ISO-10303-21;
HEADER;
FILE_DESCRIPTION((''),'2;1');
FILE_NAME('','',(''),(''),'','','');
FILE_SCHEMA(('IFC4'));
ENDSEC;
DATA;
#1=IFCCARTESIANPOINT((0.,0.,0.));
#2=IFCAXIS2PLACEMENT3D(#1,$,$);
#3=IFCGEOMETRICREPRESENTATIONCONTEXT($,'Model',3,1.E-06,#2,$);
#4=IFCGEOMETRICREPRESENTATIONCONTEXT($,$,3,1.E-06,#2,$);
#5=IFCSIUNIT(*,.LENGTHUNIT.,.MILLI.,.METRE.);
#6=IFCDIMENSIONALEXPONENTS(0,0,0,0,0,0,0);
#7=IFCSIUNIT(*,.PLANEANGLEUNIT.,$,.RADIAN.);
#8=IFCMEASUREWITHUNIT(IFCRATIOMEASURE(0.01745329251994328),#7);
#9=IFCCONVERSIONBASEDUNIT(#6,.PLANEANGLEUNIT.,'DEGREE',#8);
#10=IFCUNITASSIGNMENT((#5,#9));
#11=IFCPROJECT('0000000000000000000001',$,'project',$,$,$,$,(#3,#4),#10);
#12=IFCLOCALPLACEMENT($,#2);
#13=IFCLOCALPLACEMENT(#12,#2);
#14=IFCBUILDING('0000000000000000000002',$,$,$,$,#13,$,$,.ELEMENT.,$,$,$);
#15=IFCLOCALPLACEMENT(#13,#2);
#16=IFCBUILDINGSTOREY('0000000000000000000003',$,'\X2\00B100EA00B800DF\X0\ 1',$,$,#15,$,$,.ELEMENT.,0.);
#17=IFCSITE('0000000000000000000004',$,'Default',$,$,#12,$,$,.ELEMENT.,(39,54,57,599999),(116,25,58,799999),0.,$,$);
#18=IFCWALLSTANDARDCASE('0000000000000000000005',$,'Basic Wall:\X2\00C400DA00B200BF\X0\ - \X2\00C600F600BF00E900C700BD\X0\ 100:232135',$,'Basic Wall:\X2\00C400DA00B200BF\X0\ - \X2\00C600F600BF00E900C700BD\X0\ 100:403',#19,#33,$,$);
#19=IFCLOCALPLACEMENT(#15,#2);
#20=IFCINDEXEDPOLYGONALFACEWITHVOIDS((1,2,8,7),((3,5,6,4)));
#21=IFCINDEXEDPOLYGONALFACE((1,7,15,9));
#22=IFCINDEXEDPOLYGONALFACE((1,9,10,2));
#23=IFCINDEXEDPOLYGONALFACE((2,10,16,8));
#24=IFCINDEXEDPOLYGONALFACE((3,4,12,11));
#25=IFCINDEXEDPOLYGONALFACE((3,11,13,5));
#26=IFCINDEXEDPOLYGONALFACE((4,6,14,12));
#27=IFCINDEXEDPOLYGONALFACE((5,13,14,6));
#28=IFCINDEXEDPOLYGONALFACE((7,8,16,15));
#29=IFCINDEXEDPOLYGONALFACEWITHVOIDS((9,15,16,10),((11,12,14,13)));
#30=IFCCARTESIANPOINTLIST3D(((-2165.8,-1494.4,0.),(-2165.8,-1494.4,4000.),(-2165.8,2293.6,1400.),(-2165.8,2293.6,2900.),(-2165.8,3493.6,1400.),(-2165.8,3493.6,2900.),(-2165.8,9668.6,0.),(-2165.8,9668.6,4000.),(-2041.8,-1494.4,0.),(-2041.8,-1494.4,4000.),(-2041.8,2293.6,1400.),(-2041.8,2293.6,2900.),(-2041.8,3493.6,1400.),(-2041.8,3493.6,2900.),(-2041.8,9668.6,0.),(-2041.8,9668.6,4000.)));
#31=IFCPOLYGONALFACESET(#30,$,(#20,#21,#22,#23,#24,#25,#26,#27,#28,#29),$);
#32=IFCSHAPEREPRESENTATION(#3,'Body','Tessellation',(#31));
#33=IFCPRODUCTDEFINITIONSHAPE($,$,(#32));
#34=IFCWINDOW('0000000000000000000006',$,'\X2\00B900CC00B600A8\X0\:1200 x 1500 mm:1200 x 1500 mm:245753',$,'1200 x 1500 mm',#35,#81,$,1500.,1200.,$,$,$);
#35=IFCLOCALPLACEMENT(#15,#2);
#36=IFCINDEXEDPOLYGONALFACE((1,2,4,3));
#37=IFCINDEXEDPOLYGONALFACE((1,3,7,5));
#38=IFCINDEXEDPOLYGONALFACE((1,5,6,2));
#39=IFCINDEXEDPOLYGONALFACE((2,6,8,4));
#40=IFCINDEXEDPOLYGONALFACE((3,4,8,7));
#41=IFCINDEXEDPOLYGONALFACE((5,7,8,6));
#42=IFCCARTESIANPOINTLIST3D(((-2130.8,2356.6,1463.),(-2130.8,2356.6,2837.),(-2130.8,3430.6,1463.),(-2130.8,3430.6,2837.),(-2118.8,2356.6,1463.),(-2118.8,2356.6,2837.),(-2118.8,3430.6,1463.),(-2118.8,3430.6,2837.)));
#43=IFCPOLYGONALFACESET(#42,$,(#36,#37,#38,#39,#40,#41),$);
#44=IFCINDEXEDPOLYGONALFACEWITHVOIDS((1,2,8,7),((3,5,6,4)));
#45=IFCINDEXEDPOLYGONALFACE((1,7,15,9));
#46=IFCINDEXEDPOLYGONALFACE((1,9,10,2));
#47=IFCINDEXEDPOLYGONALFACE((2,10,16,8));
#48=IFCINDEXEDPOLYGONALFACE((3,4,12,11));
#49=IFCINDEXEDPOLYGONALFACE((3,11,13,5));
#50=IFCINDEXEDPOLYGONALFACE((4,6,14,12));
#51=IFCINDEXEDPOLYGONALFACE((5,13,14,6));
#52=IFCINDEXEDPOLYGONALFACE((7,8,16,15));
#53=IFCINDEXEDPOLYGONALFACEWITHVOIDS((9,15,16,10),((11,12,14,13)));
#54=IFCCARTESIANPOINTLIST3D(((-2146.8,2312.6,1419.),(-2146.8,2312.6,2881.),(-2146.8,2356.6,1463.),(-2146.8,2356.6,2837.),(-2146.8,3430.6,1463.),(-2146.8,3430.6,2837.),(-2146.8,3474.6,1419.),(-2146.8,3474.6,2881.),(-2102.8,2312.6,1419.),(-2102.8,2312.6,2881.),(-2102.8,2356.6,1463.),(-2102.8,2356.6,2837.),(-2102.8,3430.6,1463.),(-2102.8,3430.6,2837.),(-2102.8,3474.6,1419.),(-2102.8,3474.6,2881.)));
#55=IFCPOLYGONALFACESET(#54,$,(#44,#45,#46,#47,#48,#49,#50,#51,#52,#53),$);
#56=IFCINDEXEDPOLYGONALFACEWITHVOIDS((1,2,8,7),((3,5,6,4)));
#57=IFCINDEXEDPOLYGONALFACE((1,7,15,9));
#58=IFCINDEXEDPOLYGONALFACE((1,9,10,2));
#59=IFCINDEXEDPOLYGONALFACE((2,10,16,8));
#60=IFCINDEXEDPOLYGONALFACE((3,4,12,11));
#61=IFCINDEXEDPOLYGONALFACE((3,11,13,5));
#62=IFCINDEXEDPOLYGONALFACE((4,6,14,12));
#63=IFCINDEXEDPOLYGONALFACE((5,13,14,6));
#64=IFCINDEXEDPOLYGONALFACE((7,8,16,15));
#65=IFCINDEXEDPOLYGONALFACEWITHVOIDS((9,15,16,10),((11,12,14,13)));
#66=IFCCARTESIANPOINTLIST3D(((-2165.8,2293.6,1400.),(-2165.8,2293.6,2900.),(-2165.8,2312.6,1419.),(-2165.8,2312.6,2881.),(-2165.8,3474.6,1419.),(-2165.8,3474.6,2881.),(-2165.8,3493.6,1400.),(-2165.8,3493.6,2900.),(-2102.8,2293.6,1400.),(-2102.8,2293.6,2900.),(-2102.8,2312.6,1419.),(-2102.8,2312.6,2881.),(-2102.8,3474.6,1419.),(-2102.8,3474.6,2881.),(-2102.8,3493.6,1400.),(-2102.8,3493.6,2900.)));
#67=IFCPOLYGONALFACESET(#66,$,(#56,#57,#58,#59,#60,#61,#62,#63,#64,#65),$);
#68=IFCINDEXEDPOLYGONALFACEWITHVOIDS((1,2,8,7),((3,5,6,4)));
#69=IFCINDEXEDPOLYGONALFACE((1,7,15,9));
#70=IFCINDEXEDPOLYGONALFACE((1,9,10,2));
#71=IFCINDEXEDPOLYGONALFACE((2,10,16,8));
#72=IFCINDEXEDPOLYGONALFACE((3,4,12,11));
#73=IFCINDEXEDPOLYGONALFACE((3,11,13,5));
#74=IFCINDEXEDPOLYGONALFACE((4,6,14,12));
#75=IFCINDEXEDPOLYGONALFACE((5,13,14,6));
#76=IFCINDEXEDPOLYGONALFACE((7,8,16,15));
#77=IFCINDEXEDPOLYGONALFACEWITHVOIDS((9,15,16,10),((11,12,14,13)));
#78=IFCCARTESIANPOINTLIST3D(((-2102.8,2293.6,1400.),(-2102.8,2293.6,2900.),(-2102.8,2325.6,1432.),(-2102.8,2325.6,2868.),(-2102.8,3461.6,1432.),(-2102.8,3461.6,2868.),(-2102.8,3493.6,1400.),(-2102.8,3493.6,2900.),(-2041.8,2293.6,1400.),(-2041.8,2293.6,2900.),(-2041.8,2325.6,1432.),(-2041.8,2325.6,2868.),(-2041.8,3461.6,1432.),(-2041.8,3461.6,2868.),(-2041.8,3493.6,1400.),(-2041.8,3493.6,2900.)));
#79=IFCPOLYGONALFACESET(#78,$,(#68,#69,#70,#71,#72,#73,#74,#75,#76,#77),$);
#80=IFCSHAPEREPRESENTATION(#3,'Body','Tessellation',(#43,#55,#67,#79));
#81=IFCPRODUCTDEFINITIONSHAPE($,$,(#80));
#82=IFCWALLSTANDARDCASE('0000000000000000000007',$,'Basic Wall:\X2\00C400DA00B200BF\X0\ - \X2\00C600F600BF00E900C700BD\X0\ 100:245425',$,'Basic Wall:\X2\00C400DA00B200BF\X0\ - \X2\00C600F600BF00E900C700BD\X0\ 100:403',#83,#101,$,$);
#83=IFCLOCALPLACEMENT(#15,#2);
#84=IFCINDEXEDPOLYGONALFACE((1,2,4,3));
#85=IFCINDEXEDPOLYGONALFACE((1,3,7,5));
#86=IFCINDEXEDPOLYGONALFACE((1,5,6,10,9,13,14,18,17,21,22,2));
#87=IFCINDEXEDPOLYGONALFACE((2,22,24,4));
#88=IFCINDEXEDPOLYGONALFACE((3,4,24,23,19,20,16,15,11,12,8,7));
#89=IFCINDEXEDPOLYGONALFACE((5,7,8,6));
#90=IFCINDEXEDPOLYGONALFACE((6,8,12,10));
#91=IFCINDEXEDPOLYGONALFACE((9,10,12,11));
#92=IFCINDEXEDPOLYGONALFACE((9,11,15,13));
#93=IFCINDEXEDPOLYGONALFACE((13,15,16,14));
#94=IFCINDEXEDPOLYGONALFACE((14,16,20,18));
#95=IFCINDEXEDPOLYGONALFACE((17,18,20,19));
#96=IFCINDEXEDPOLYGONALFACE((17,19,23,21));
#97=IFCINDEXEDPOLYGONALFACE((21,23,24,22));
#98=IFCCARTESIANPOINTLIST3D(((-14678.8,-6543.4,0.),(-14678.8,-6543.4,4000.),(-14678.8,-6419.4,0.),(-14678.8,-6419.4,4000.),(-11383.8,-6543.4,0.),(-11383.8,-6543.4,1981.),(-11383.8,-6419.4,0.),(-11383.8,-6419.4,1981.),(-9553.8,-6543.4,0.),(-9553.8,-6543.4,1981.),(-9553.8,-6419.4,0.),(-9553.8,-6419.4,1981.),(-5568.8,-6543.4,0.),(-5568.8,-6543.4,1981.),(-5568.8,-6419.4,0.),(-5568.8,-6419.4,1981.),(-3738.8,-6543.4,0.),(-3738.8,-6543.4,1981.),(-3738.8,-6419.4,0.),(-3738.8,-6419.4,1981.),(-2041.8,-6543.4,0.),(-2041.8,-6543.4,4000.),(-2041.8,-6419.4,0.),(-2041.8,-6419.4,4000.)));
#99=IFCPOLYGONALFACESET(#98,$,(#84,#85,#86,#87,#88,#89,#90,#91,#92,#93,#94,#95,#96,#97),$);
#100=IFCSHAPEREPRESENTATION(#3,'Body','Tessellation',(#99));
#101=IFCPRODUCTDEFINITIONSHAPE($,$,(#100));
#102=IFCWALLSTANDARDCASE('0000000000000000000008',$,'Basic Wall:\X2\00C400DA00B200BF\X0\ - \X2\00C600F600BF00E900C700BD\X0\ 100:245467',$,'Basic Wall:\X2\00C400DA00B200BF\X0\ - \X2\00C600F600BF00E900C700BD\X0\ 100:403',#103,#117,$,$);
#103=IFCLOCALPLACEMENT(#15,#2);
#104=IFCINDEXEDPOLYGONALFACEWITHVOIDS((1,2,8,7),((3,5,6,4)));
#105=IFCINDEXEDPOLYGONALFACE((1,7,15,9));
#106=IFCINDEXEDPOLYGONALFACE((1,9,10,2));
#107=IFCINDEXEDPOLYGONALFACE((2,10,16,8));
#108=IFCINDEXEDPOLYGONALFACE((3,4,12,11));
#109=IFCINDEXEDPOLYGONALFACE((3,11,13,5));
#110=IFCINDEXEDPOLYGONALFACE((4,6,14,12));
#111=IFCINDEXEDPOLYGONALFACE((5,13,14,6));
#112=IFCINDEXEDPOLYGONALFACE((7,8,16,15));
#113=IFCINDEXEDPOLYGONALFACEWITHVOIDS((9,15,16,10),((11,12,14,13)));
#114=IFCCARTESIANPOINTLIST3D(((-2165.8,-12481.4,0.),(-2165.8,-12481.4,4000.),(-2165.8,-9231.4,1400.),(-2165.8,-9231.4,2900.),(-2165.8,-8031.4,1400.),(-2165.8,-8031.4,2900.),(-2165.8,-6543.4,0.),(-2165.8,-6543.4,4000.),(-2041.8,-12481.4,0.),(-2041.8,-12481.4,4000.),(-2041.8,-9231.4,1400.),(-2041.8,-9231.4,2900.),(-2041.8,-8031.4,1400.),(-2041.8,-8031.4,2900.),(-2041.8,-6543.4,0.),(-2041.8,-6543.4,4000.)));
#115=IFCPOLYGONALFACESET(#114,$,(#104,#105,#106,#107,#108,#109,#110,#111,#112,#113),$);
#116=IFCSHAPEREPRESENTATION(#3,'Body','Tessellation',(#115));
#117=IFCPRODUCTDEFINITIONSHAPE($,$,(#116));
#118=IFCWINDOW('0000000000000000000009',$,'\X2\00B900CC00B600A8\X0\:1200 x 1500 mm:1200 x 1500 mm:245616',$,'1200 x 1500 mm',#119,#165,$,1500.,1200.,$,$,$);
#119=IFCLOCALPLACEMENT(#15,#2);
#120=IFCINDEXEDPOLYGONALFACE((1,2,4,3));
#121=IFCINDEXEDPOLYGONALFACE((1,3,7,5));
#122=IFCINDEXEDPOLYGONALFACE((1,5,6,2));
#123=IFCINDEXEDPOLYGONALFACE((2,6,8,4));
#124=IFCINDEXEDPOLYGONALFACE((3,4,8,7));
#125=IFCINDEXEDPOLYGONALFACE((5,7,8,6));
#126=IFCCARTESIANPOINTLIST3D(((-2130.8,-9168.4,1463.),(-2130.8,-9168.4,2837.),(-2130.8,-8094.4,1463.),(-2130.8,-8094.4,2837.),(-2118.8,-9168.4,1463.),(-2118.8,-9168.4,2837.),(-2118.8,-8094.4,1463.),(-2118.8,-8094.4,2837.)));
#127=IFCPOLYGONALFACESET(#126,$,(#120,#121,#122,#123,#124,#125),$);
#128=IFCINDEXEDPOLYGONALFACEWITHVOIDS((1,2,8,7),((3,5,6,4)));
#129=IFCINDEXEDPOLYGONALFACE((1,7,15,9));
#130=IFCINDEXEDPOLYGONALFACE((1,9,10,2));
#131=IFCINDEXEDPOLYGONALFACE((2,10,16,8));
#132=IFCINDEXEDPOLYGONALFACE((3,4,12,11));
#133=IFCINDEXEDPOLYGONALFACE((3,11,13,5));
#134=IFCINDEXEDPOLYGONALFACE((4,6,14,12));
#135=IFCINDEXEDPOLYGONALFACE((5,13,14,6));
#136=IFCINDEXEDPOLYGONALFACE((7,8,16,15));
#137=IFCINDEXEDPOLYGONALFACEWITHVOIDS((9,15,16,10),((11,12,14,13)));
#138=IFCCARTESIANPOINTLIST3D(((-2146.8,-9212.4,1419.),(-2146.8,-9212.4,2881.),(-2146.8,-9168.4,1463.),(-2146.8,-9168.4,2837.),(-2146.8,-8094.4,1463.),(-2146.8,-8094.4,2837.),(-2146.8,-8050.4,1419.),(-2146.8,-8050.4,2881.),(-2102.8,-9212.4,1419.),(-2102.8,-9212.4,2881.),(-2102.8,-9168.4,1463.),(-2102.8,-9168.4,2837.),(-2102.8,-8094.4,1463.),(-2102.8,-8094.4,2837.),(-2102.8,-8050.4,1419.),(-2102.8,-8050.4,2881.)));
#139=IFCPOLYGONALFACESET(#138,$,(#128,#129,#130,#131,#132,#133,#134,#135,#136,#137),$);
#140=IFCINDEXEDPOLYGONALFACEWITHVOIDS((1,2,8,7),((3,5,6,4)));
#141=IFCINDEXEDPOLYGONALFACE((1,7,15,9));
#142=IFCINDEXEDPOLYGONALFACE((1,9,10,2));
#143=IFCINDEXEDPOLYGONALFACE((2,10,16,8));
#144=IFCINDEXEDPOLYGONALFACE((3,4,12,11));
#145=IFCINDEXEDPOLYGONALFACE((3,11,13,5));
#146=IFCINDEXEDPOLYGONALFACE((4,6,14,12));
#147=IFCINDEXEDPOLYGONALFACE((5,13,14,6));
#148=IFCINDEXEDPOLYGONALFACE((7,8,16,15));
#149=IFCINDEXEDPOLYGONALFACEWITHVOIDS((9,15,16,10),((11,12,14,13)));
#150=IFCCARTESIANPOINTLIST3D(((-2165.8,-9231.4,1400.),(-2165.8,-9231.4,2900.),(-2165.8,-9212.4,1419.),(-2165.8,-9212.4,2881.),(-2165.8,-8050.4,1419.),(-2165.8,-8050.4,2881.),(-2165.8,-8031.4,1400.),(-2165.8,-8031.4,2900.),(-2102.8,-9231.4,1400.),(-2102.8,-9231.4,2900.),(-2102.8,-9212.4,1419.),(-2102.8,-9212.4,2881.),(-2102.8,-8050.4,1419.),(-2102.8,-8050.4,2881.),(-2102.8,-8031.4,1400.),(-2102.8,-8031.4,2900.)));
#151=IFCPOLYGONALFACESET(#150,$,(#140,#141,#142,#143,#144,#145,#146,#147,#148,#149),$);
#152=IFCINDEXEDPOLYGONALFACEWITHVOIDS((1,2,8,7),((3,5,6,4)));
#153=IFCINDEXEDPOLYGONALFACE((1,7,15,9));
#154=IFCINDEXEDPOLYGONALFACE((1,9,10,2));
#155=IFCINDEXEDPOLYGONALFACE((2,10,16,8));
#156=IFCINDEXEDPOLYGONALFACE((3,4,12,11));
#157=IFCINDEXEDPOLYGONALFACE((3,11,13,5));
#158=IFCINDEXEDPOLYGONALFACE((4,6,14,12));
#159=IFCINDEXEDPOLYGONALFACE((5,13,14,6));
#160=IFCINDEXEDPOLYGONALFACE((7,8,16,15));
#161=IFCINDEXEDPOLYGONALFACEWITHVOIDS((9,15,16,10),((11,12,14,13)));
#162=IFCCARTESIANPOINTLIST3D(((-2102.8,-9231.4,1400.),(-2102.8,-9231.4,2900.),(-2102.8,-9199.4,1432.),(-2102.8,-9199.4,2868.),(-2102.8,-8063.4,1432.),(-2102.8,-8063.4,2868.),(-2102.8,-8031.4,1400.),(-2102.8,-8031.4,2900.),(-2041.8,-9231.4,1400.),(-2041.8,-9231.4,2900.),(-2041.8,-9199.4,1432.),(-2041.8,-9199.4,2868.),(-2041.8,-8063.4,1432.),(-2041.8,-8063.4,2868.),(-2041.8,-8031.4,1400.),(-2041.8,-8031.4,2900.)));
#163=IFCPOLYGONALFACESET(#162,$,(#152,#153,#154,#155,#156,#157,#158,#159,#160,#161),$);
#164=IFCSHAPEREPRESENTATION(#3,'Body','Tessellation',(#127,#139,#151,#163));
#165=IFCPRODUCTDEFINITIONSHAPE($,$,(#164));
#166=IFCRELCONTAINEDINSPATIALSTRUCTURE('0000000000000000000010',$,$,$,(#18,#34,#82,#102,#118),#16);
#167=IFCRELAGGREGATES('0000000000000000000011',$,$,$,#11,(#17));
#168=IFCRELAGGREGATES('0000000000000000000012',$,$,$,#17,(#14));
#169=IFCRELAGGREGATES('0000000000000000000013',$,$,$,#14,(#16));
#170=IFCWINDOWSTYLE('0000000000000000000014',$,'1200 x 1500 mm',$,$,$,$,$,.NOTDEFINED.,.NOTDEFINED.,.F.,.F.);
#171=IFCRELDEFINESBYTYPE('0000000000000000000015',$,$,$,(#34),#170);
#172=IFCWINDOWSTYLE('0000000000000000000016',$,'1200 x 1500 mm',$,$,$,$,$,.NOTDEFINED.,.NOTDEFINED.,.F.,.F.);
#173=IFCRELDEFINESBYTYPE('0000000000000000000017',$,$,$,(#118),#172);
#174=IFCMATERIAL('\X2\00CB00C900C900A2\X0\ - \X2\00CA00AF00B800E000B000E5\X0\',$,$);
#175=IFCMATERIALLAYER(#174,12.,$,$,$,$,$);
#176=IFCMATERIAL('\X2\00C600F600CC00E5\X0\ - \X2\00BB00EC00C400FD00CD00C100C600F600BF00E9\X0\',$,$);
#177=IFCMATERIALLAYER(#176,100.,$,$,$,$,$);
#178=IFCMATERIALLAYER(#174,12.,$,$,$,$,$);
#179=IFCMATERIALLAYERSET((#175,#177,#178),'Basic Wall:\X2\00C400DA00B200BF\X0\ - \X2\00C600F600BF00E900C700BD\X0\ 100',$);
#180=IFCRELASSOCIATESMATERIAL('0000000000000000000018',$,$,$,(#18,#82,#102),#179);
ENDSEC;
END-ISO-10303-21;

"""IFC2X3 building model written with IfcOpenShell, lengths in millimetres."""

from ifc_helpers import new_model, entity, si_unit, converted_unit, frame, frame_2d, origin, origin_2d_with_axis, place, context, project, spatial, polyline, rectangle, outline, extrude, source, transform, mapped, material, layer, layer_set, layer_usage, type_object, type_shapes, element, fill, save


model = new_model("IFC2X3")

# Units and contexts
model_context = context("Model", 3, precision=1e-06, world=origin())
context_of_model = context(None, 3, precision=1e-06, world=origin())
ifc_project = project(units=[si_unit("LENGTHUNIT", "METRE", prefix="MILLI"), converted_unit("PLANEANGLEUNIT", "DEGREE", entity("IfcRatioMeasure", 0.01745329251994328), si_unit("PLANEANGLEUNIT", "RADIAN"), dimensions=[0, 0, 0, 0, 0, 0, 0])], contexts=[model_context, context_of_model])

# Site, building, storey
site_placement = place(None, origin())
site = spatial("IfcSite", under=ifc_project, at=site_placement, Name="Default", CompositionType="ELEMENT", RefLatitude=(39, 54, 57, 599999), RefLongitude=(116, 25, 58, 799999), RefElevation=0.0)
building_placement = place(site_placement, origin())
building = spatial("IfcBuilding", under=site, at=building_placement, CompositionType="ELEMENT")
storey_placement = place(building_placement, origin())
storey = spatial("IfcBuildingStorey", under=building, at=storey_placement, Name="±ê¸ß 1", CompositionType="ELEMENT", Elevation=0.0)

# Shared definitions
ifc_material_1 = material(Name="ËÉÉ¢ - Ê¯¸à°å")

# Shared definitions
ifc_layer_1 = layer(ifc_material_1, 12.0)
ifc_material_2 = material(Name="ÆöÌå - »ìÄýÍÁÆö¿é")
ifc_layer_2 = layer(ifc_material_2, 100.0)
ifc_layer_3 = layer(ifc_material_1, 12.0)
ifc_layer_set_1 = layer_set([ifc_layer_1, ifc_layer_2, ifc_layer_3], Name="Basic Wall:ÄÚ²¿ - Æö¿éÇ½ 100")

# Wall, opening, window
ifc_layer_usage_1 = layer_usage(ifc_layer_set_1, "AXIS2", "NEGATIVE", 62.0)
wall_1_placement = place(storey_placement, frame((-2103.8, -1494.4, 0.0), z_axis=(0.0, 0.0, 1.0), x_axis=(0.0, 1.0, 0.0)))
wall_1 = element("IfcWallStandardCase", 1, at=wall_1_placement, inside=storey, material=ifc_layer_usage_1, Name="Basic Wall:ÄÚ²¿ - Æö¿éÇ½ 100:232135", ObjectType="Basic Wall:ÄÚ²¿ - Æö¿éÇ½ 100:403", context=model_context, shape_type="SweptSolid", body=[
    extrude(rectangle(XDim=11163.0, YDim=124.0, at=frame_2d((5581.5, 0.0), x_axis=(-1.0, 0.0))), origin(), (0.0, 0.0, 1.0), 4000.0),
])
opening_1_placement = place(wall_1_placement, frame((3788.0, -62.0, 1400.0)))
opening_1 = element("IfcOpeningElement", 2, at=opening_1_placement, cuts=wall_1, ObjectType="Opening", context=model_context, shape_type="SweptSolid", body=[
    extrude(rectangle(XDim=1500.0, YDim=1200.0, at=frame_2d((750.0, 600.0), x_axis=(1.0, 0.0))), frame((0.0, 0.0, 0.0), z_axis=(0.0, 1.0, 0.0), x_axis=(0.0, 0.0, 1.0)), (0.0, 0.0, 1.0), 124.0),
])
window_style_1 = type_object("IfcWindowStyle", Name="1200 x 1500 mm", ConstructionType="NOTDEFINED", OperationType="NOTDEFINED", ParameterTakesPrecedence=False, Sizeable=False)
shared_shape_1 = source(origin(), model_context, "Body", "SweptSolid", [
    extrude(rectangle(XDim=12.0, YDim=1074.0, at=origin_2d_with_axis()), frame((600.0, 83.0, 63.0), z_axis=(0.0, 0.0, 1.0), x_axis=(0.0, -1.0, 0.0)), (0.0, 0.0, 1.0), 1374.0),
    extrude(outline(polyline([(-581.0, -731.0), (581.0, -731.0), (581.0, 731.0), (-581.0, 731.0), (-581.0, -731.0)]), holes=[polyline([(-537.0, -687.0), (-537.0, 687.0), (537.0, 687.0), (537.0, -687.0), (-537.0, -687.0)])]), frame((600.0, 61.0, 750.0), z_axis=(0.0, 1.0, 0.0), x_axis=(1.0, 0.0, 0.0)), (0.0, 0.0, 1.0), 44.0),
    extrude(outline(polyline([(-600.0, -750.0), (600.0, -750.0), (600.0, 750.0), (-600.0, 750.0), (-600.0, -750.0)]), holes=[polyline([(-581.0, -731.0), (-581.0, 731.0), (581.0, 731.0), (581.0, -731.0), (-581.0, -731.0)])]), frame((600.0, 61.0, 750.0), z_axis=(0.0, 1.0, 0.0), x_axis=(1.0, 0.0, 0.0)), (0.0, 0.0, 1.0), 63.0),
    extrude(outline(polyline([(-600.0, -750.0), (600.0, -750.0), (600.0, 750.0), (-600.0, 750.0), (-600.0, -750.0)]), holes=[polyline([(-568.0, -718.0), (-568.0, 718.0), (568.0, 718.0), (568.0, -718.0), (-568.0, -718.0)])]), frame((600.0, 0.0, 750.0), z_axis=(0.0, 1.0, 0.0), x_axis=(1.0, 0.0, 0.0)), (0.0, 0.0, 1.0), 61.0),
])
type_shapes(window_style_1, [shared_shape_1])
window_1_placement = place(opening_1_placement, origin())
window_1 = element("IfcWindow", 3, at=window_1_placement, inside=storey, type_object=window_style_1, Name="¹Ì¶¨:1200 x 1500 mm:1200 x 1500 mm:245753", ObjectType="1200 x 1500 mm", OverallHeight=1500.0, OverallWidth=1200.0, context=model_context, shape_type="MappedRepresentation", body=[
    mapped(shared_shape_1, transform((0.0, 0.0, 0.0), scale=1.0)),
])
fill(opening_1, window_1)

# Wall, openings
ifc_layer_usage_2 = layer_usage(ifc_layer_set_1, "AXIS2", "NEGATIVE", 62.0)
wall_2_placement = place(storey_placement, frame((-14678.8, -6481.4, 0.0)))
wall_2 = element("IfcWallStandardCase", 4, at=wall_2_placement, inside=storey, material=ifc_layer_usage_2, Name="Basic Wall:ÄÚ²¿ - Æö¿éÇ½ 100:245425", ObjectType="Basic Wall:ÄÚ²¿ - Æö¿éÇ½ 100:403", context=model_context, shape_type="SweptSolid", body=[
    extrude(rectangle(XDim=12637.0, YDim=124.0, at=frame_2d((6318.5, 0.0), x_axis=(-1.0, 0.0))), origin(), (0.0, 0.0, 1.0), 4000.0),
])
opening_2_placement = place(wall_2_placement, frame((10940.0, 62.0, 0.0)))
element("IfcOpeningElement", 5, at=opening_2_placement, cuts=wall_2, ObjectType="Opening", context=model_context, shape_type="SweptSolid", body=[
    extrude(rectangle(XDim=1981.0, YDim=1830.0, at=frame_2d((990.5, 915.0), x_axis=(1.0, 0.0))), frame((0.0, 0.0, 0.0), z_axis=(0.0, -1.0, 0.0), x_axis=(0.0, 0.0, 1.0)), (0.0, 0.0, 1.0), 124.0),
])
opening_3_placement = place(wall_2_placement, frame((5125.0, 62.0, 0.0)))
element("IfcOpeningElement", 6, at=opening_3_placement, cuts=wall_2, ObjectType="Opening", context=model_context, shape_type="SweptSolid", body=[
    extrude(rectangle(XDim=1981.0, YDim=1830.0, at=frame_2d((990.5, 915.0), x_axis=(1.0, 0.0))), frame((0.0, 0.0, 0.0), z_axis=(0.0, -1.0, 0.0), x_axis=(0.0, 0.0, 1.0)), (0.0, 0.0, 1.0), 124.0),
])

# Wall, opening, window
ifc_layer_usage_3 = layer_usage(ifc_layer_set_1, "AXIS2", "NEGATIVE", 62.0)
wall_3_placement = place(storey_placement, frame((-2103.8, -6543.4, 0.0), z_axis=(0.0, 0.0, 1.0), x_axis=(0.0, -1.0, 0.0)))
wall_3 = element("IfcWallStandardCase", 7, at=wall_3_placement, inside=storey, material=ifc_layer_usage_3, Name="Basic Wall:ÄÚ²¿ - Æö¿éÇ½ 100:245467", ObjectType="Basic Wall:ÄÚ²¿ - Æö¿éÇ½ 100:403", context=model_context, shape_type="SweptSolid", body=[
    extrude(rectangle(XDim=5938.0, YDim=124.0, at=frame_2d((2969.0, 0.0), x_axis=(-1.0, 0.0))), origin(), (0.0, 0.0, 1.0), 4000.0),
])
opening_4_placement = place(wall_3_placement, frame((1488.0, -62.0, 1400.0)))
opening_4 = element("IfcOpeningElement", 8, at=opening_4_placement, cuts=wall_3, ObjectType="Opening", context=model_context, shape_type="SweptSolid", body=[
    extrude(rectangle(XDim=1500.0, YDim=1200.0, at=frame_2d((750.0, 600.0), x_axis=(1.0, 0.0))), frame((0.0, 0.0, 0.0), z_axis=(0.0, 1.0, 0.0), x_axis=(0.0, 0.0, 1.0)), (0.0, 0.0, 1.0), 124.0),
])
window_style_2 = type_object("IfcWindowStyle", Name="1200 x 1500 mm", ConstructionType="NOTDEFINED", OperationType="NOTDEFINED", ParameterTakesPrecedence=False, Sizeable=False)
shared_shape_2 = source(origin(), model_context, "Body", "SweptSolid", [
    extrude(rectangle(XDim=12.0, YDim=1074.0, at=origin_2d_with_axis()), frame((600.0, 83.0, 63.0), z_axis=(0.0, 0.0, 1.0), x_axis=(0.0, -1.0, 0.0)), (0.0, 0.0, 1.0), 1374.0),
    extrude(outline(polyline([(-581.0, -731.0), (581.0, -731.0), (581.0, 731.0), (-581.0, 731.0), (-581.0, -731.0)]), holes=[polyline([(-537.0, -687.0), (-537.0, 687.0), (537.0, 687.0), (537.0, -687.0), (-537.0, -687.0)])]), frame((600.0, 61.0, 750.0), z_axis=(0.0, 1.0, 0.0), x_axis=(1.0, 0.0, 0.0)), (0.0, 0.0, 1.0), 44.0),
    extrude(outline(polyline([(-600.0, -750.0), (600.0, -750.0), (600.0, 750.0), (-600.0, 750.0), (-600.0, -750.0)]), holes=[polyline([(-581.0, -731.0), (-581.0, 731.0), (581.0, 731.0), (581.0, -731.0), (-581.0, -731.0)])]), frame((600.0, 61.0, 750.0), z_axis=(0.0, 1.0, 0.0), x_axis=(1.0, 0.0, 0.0)), (0.0, 0.0, 1.0), 63.0),
    extrude(outline(polyline([(-600.0, -750.0), (600.0, -750.0), (600.0, 750.0), (-600.0, 750.0), (-600.0, -750.0)]), holes=[polyline([(-568.0, -718.0), (-568.0, 718.0), (568.0, 718.0), (568.0, -718.0), (-568.0, -718.0)])]), frame((600.0, 0.0, 750.0), z_axis=(0.0, 1.0, 0.0), x_axis=(1.0, 0.0, 0.0)), (0.0, 0.0, 1.0), 61.0),
])
type_shapes(window_style_2, [shared_shape_2])
window_2_placement = place(opening_4_placement, frame((1200.0, 124.0, 0.0), z_axis=(0.0, 0.0, 1.0), x_axis=(-1.0, 0.0, 0.0)))
window_2 = element("IfcWindow", 9, at=window_2_placement, inside=storey, type_object=window_style_2, Name="¹Ì¶¨:1200 x 1500 mm:1200 x 1500 mm:245616", ObjectType="1200 x 1500 mm", OverallHeight=1500.0, OverallWidth=1200.0, context=model_context, shape_type="MappedRepresentation", body=[
    mapped(shared_shape_2, transform((0.0, 0.0, 0.0), scale=1.0)),
])
fill(opening_4, window_2)

save(model, "model.ifc")
